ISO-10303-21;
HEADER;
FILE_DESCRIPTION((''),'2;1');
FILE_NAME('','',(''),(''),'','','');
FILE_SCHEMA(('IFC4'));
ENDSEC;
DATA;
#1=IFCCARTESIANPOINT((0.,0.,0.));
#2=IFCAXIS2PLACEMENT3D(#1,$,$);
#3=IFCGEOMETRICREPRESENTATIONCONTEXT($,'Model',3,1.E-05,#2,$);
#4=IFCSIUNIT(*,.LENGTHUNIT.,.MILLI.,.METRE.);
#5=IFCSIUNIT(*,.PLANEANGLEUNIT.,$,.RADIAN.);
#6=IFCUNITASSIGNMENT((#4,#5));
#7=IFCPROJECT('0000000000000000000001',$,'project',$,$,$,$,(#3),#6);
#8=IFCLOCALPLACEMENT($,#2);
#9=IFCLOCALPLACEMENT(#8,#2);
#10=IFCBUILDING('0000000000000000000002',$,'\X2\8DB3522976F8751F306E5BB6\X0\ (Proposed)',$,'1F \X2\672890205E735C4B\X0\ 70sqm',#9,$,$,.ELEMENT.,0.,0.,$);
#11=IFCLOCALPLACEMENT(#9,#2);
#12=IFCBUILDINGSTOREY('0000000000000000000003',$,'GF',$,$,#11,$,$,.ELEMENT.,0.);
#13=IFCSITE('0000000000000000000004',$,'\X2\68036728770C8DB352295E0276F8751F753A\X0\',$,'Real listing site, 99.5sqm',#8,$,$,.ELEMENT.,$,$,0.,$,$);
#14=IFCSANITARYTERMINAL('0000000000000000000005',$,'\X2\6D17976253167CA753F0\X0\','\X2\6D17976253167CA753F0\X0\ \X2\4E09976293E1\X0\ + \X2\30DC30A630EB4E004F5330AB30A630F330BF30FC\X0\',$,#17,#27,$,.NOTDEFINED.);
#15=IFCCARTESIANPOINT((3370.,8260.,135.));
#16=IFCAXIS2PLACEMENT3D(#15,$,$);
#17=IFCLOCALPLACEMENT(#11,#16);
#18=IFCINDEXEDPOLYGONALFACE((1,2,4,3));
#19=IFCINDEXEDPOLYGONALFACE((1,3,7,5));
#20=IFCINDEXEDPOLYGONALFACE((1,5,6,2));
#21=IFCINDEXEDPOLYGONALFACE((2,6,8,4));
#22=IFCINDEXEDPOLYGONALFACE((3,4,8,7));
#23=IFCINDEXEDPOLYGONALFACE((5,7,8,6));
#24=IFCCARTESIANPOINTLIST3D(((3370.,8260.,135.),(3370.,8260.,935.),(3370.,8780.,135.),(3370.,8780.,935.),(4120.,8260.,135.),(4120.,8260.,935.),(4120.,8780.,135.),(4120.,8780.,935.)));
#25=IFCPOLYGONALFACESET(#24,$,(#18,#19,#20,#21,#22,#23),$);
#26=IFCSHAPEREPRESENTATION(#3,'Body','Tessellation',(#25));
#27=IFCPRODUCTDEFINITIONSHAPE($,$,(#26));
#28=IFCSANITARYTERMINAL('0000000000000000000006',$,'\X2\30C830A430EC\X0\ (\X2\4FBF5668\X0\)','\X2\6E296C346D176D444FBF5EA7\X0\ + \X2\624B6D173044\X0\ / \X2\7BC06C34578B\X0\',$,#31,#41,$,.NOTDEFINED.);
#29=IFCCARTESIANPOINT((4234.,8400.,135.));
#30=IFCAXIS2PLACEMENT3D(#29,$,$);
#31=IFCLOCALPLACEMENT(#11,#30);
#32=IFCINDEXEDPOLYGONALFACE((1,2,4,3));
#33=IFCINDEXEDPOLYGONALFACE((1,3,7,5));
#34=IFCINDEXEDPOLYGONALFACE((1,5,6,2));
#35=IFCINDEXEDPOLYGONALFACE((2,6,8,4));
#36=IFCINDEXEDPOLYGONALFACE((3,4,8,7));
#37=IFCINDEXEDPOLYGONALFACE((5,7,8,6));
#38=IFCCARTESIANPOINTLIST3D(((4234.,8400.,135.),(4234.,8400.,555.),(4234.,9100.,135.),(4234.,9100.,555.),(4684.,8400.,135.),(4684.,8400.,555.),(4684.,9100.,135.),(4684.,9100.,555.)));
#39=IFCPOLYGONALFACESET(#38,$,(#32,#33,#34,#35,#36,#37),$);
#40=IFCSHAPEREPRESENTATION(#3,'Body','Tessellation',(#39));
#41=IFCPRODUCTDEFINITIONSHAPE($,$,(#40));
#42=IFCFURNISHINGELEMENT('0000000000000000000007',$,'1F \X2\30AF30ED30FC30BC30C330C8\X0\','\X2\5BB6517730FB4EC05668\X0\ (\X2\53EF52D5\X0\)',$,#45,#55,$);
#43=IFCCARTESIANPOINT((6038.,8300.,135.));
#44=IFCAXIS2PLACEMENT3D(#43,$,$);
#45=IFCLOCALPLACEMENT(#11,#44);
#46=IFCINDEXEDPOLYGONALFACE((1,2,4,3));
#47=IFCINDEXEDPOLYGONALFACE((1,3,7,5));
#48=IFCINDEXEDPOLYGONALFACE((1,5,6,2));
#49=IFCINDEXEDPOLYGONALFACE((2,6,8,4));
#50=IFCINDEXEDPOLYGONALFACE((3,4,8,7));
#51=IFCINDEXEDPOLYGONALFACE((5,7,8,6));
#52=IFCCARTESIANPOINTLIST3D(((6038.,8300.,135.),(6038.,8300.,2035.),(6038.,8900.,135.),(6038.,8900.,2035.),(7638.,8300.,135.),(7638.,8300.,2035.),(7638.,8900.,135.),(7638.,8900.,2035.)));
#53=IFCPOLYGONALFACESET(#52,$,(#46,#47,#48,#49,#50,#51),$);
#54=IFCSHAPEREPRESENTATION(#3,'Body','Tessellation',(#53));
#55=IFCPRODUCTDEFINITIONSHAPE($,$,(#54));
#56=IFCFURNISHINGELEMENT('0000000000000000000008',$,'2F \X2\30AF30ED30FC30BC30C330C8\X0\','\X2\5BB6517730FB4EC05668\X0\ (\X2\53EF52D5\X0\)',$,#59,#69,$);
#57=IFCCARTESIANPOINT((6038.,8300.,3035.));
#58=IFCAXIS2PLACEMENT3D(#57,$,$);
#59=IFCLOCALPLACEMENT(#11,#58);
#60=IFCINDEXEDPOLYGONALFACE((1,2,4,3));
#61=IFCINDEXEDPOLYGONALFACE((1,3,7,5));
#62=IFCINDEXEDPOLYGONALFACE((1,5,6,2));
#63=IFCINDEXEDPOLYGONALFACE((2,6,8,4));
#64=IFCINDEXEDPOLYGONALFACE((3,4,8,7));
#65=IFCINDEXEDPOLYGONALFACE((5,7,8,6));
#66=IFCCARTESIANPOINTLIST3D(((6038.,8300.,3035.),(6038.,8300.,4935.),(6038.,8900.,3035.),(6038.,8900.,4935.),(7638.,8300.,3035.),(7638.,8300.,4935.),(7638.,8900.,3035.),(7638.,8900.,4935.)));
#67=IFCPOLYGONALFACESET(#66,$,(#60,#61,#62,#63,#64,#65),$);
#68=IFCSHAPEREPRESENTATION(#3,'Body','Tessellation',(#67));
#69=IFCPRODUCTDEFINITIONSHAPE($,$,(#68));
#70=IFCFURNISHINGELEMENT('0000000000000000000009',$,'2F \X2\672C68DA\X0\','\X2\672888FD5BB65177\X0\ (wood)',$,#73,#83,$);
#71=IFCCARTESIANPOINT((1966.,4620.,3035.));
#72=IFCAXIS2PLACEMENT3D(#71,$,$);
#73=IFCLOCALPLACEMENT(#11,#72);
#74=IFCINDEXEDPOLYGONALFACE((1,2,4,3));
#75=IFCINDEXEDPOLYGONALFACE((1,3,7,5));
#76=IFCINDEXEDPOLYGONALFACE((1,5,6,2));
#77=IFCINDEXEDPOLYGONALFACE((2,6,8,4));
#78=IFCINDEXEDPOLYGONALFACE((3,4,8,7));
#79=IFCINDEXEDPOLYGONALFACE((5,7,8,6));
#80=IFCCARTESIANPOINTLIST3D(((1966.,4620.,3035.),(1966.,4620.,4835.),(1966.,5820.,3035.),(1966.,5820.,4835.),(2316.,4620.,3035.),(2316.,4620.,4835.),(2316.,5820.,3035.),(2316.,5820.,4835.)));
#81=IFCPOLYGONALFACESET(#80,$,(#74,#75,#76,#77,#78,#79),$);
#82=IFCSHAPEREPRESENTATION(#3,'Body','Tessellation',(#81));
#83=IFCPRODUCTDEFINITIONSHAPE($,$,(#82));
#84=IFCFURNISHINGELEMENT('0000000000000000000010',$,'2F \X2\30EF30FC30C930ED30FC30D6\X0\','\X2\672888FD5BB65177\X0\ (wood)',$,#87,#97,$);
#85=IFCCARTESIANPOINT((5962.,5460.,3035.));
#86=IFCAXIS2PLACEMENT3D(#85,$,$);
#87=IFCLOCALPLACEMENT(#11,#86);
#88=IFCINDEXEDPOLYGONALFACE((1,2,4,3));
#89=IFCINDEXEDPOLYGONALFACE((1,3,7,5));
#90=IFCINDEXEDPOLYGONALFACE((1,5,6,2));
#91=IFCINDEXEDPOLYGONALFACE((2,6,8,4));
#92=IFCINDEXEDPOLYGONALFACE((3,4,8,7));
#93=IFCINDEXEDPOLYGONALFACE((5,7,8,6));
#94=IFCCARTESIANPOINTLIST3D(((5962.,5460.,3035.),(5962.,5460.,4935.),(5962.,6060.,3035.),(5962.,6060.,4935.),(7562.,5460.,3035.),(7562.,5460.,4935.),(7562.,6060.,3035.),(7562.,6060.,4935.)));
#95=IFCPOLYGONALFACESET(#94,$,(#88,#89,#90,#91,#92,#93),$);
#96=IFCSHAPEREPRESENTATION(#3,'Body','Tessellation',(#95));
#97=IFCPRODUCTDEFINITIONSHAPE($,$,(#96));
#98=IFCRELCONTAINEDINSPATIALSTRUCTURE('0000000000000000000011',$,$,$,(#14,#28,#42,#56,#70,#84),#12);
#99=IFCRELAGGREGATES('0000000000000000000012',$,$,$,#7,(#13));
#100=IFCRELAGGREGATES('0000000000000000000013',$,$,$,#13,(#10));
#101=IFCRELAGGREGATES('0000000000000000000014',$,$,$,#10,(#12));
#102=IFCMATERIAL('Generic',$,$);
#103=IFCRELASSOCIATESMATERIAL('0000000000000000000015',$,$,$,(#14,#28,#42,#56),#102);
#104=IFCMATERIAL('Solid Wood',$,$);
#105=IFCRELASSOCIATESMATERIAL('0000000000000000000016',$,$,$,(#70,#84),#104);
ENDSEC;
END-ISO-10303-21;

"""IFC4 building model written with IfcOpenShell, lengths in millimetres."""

from ifc_helpers import new_model, si_unit, frame, frame_2d, origin, place, context, project, spatial, rectangle, extrude, material, element, save


model = new_model("IFC4")

# Units and contexts
model_context = context("Model", 3, precision=1e-05, world=origin())
ifc_project = project(units=[si_unit("LENGTHUNIT", "METRE", prefix="MILLI"), si_unit("PLANEANGLEUNIT", "RADIAN")], contexts=[model_context])

# Site, building, storey
site_placement = place(None, origin())
site = spatial("IfcSite", under=ifc_project, at=site_placement, Name="栃木県足利市相生町", ObjectType="Real listing site, 99.5sqm", CompositionType="ELEMENT", RefElevation=0.0)
building_placement = place(site_placement, origin())
building = spatial("IfcBuilding", under=site, at=building_placement, Name="足利相生の家 (Proposed)", ObjectType="1F 木造平屋 70sqm", CompositionType="ELEMENT", ElevationOfRefHeight=0.0, ElevationOfTerrain=0.0)
storey_placement = place(building_placement, origin())
storey = spatial("IfcBuildingStorey", under=building, at=storey_placement, Name="GF", CompositionType="ELEMENT", Elevation=0.0)

# Shared definitions
ifc_material_1 = material(Name="Solid Wood")

# Shared definitions
ifc_material_2 = material(Name="Generic")

# Sanitary terminals
sanitary_terminal_1_placement = place(storey_placement, frame((3370.0, 8260.0, 135.0)))
element("IfcSanitaryTerminal", 1, at=sanitary_terminal_1_placement, inside=storey, material=ifc_material_2, Name="洗面化粧台", Description="洗面化粧台 三面鏡 + ボウル一体カウンター", PredefinedType="NOTDEFINED", context=model_context, shape_type="SweptSolid", body=[
    extrude(rectangle(XDim=750.0, YDim=520.0, at=frame_2d((375.0, 260.0))), frame((3370.0, 8260.0, 135.0)), (0.0, 0.0, 1.0), 800.0),
])
sanitary_terminal_2_placement = place(storey_placement, frame((4234.0, 8400.0, 135.0)))
element("IfcSanitaryTerminal", 2, at=sanitary_terminal_2_placement, inside=storey, material=ifc_material_2, Name="トイレ (便器)", Description="温水洗浄便座 + 手洗い / 節水型", PredefinedType="NOTDEFINED", context=model_context, shape_type="SweptSolid", body=[
    extrude(rectangle(XDim=450.0, YDim=700.0, at=frame_2d((225.0, 350.0))), frame((4234.0, 8400.0, 135.0)), (0.0, 0.0, 1.0), 420.0),
])

# Furnishing elements
furnishing_1_placement = place(storey_placement, frame((6038.0, 8300.0, 135.0)))
element("IfcFurnishingElement", 3, at=furnishing_1_placement, inside=storey, material=ifc_material_2, Name="1F クローゼット", Description="家具・什器 (可動)", context=model_context, shape_type="SweptSolid", body=[
    extrude(rectangle(XDim=1600.0, YDim=600.0, at=frame_2d((800.0, 300.0))), frame((6038.0, 8300.0, 135.0)), (0.0, 0.0, 1.0), 1900.0),
])
furnishing_2_placement = place(storey_placement, frame((6038.0, 8300.0, 3035.0)))
element("IfcFurnishingElement", 4, at=furnishing_2_placement, inside=storey, material=ifc_material_2, Name="2F クローゼット", Description="家具・什器 (可動)", context=model_context, shape_type="SweptSolid", body=[
    extrude(rectangle(XDim=1600.0, YDim=600.0, at=frame_2d((800.0, 300.0))), frame((6038.0, 8300.0, 3035.0)), (0.0, 0.0, 1.0), 1900.0),
])
furnishing_3_placement = place(storey_placement, frame((1966.0, 4620.0, 3035.0)))
element("IfcFurnishingElement", 5, at=furnishing_3_placement, inside=storey, material=ifc_material_1, Name="2F 本棚", Description="木製家具 (wood)", context=model_context, shape_type="SweptSolid", body=[
    extrude(rectangle(XDim=350.0, YDim=1200.0, at=frame_2d((175.0, 600.0))), frame((1966.0, 4620.0, 3035.0)), (0.0, 0.0, 1.0), 1800.0),
])
furnishing_4_placement = place(storey_placement, frame((5962.0, 5460.0, 3035.0)))
element("IfcFurnishingElement", 6, at=furnishing_4_placement, inside=storey, material=ifc_material_1, Name="2F ワードローブ", Description="木製家具 (wood)", context=model_context, shape_type="SweptSolid", body=[
    extrude(rectangle(XDim=1600.0, YDim=600.0, at=frame_2d((800.0, 300.0))), frame((5962.0, 5460.0, 3035.0)), (0.0, 0.0, 1.0), 1900.0),
])

save(model, "model.ifc")
